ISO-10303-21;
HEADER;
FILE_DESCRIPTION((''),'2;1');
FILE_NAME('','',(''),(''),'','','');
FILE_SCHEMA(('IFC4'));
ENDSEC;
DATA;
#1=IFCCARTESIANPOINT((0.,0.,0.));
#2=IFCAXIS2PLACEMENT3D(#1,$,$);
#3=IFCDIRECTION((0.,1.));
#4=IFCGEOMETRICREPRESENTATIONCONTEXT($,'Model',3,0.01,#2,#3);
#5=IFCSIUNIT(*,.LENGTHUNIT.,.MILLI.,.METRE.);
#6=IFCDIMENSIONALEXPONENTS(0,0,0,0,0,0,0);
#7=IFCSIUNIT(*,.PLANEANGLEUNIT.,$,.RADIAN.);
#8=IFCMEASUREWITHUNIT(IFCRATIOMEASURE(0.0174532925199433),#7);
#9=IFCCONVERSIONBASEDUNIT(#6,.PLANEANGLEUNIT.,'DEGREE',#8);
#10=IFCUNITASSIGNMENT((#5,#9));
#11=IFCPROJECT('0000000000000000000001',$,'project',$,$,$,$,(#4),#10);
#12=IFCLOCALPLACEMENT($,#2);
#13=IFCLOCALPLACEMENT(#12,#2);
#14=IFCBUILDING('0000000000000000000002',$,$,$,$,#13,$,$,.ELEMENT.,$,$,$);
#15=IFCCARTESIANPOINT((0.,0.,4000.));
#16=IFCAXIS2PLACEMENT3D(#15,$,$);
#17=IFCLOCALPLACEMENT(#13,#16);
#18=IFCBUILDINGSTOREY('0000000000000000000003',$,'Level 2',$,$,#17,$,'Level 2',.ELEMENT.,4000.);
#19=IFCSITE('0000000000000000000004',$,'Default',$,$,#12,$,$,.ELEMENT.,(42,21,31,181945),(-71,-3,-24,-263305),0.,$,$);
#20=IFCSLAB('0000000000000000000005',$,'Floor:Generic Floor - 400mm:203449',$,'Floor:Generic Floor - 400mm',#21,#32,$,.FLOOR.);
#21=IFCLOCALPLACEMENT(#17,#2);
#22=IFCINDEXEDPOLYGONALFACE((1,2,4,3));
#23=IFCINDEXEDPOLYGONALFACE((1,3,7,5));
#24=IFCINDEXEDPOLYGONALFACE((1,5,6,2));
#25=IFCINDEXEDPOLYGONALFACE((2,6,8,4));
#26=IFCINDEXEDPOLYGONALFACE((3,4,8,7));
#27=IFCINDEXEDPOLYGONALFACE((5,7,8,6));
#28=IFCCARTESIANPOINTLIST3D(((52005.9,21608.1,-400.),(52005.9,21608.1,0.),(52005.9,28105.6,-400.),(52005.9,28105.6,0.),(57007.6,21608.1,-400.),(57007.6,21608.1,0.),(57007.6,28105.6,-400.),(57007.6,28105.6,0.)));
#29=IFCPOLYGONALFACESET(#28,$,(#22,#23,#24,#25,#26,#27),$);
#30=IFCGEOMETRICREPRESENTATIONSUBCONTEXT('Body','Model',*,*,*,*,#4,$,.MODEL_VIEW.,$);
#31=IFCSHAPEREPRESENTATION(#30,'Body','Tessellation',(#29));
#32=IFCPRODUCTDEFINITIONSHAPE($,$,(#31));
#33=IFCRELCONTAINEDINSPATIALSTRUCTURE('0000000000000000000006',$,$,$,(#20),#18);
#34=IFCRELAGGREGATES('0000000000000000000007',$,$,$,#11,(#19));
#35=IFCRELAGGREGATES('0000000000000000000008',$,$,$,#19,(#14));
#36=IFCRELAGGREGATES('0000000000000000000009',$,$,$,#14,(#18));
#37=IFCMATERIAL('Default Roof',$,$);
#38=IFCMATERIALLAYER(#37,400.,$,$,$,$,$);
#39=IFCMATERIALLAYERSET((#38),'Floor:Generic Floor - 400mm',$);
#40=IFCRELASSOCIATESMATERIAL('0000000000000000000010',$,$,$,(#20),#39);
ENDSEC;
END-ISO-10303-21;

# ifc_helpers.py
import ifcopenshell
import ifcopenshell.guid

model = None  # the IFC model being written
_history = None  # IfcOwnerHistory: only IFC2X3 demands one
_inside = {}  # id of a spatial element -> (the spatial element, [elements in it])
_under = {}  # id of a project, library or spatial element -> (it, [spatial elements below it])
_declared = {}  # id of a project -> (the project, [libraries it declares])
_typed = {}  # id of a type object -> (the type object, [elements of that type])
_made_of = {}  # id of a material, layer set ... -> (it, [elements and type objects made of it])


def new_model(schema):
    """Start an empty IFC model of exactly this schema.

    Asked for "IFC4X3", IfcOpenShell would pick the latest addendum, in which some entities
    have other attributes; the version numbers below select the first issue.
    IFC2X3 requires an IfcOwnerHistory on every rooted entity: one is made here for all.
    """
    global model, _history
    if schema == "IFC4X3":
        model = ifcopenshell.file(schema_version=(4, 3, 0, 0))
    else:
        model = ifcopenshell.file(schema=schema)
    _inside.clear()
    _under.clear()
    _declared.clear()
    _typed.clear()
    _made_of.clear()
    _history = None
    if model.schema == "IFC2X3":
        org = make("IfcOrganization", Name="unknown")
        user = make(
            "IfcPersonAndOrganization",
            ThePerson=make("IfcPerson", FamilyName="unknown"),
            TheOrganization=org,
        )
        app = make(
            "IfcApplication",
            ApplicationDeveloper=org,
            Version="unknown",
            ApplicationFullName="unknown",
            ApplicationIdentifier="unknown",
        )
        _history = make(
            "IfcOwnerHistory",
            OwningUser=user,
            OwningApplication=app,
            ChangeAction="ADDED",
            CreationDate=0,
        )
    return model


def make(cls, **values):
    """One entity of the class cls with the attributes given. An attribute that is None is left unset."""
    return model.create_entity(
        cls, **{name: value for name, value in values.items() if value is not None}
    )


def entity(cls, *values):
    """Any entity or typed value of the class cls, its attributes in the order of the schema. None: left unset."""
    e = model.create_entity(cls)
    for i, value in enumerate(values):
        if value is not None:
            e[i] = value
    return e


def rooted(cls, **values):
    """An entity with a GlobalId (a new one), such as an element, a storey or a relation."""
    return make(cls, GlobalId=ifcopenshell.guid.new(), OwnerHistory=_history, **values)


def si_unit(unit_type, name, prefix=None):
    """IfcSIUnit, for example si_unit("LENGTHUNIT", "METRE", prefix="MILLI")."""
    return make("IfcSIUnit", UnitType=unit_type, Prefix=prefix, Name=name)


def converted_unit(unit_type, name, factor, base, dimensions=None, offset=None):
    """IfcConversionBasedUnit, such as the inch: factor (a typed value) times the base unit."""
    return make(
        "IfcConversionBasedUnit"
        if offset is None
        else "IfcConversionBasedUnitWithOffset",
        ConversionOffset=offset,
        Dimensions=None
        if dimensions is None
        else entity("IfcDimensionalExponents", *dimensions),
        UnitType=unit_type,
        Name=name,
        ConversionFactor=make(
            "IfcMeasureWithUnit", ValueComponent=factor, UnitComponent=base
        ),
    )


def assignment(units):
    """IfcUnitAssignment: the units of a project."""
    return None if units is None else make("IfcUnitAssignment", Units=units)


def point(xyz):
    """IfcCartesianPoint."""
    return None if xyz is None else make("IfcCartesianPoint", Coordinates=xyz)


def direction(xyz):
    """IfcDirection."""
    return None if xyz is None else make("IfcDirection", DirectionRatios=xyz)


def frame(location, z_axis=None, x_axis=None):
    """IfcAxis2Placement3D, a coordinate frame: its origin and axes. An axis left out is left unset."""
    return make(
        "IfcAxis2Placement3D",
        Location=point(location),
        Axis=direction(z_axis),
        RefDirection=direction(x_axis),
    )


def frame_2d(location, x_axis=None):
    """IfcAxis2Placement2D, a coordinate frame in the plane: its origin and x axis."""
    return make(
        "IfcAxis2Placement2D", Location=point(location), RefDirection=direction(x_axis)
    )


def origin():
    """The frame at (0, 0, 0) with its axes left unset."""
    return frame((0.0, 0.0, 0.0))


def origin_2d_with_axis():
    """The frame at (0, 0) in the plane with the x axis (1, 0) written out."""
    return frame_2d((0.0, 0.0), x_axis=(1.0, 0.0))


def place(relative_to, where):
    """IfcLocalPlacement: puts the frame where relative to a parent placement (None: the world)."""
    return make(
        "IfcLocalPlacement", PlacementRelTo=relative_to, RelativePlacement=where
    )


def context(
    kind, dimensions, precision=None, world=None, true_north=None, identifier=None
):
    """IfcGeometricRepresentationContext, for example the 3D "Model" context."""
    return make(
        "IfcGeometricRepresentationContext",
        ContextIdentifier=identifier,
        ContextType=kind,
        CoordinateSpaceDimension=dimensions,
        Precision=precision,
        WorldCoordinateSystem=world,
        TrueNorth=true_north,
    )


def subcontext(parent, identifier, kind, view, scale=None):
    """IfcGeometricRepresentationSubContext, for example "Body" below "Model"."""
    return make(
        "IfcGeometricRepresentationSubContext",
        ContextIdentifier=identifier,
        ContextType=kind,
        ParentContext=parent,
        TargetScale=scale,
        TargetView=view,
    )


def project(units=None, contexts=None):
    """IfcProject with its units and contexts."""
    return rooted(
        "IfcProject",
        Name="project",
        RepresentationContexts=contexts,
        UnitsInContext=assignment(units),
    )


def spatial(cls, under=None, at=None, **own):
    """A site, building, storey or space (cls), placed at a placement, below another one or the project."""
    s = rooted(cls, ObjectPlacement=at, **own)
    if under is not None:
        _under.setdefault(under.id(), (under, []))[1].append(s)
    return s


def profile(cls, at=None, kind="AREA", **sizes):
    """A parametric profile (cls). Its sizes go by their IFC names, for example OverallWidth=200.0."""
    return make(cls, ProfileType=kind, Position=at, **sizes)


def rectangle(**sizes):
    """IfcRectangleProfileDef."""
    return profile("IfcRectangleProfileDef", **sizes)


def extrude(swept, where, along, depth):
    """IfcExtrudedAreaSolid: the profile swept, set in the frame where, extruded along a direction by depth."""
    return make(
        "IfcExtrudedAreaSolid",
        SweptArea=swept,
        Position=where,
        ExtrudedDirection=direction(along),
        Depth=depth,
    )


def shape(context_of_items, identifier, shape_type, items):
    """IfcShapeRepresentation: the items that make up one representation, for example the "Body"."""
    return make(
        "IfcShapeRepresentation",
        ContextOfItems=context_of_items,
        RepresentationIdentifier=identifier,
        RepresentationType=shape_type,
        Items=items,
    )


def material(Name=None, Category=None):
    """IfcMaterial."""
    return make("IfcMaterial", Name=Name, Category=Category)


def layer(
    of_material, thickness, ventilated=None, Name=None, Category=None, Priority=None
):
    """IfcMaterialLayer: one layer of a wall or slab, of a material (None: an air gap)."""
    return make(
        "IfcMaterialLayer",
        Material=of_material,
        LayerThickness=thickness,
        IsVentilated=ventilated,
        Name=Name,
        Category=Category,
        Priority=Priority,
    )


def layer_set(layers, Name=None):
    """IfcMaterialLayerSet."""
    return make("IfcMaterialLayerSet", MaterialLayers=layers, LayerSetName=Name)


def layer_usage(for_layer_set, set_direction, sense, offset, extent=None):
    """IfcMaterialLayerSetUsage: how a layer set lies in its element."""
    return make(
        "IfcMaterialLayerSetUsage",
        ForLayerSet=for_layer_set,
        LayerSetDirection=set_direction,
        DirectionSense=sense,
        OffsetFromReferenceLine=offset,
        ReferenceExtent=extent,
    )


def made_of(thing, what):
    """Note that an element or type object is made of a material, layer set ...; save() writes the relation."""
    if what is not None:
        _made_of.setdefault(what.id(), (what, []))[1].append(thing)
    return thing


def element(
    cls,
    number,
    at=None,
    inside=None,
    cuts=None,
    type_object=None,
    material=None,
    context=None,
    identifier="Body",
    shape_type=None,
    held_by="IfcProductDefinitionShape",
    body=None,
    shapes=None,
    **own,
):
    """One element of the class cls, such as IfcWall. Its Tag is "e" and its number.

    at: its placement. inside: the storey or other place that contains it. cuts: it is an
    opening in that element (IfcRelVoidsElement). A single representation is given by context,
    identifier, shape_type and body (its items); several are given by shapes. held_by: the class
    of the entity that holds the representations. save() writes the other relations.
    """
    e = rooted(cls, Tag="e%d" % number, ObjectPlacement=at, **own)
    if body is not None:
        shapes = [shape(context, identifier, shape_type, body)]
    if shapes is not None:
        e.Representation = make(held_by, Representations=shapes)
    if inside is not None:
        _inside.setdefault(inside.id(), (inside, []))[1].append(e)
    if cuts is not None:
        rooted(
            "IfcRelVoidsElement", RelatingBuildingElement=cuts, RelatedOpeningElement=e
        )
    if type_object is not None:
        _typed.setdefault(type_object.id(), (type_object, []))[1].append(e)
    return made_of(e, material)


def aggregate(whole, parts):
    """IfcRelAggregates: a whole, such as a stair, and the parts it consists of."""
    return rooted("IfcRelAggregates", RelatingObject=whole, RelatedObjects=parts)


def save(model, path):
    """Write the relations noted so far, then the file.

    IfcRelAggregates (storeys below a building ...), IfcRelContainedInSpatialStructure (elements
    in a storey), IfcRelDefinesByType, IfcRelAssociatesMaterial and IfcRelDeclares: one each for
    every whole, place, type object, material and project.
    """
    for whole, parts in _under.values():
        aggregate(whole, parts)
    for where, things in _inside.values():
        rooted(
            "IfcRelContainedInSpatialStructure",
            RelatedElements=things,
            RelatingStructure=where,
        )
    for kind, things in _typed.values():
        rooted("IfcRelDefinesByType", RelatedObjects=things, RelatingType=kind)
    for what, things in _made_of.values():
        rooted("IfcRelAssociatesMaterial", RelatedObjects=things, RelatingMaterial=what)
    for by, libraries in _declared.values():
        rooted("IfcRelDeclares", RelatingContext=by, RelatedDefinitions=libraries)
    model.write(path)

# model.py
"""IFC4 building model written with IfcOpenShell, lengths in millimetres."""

from ifc_helpers import new_model, entity, si_unit, converted_unit, direction, frame, origin, origin_2d_with_axis, place, context, subcontext, project, spatial, rectangle, extrude, material, layer, layer_set, layer_usage, element, save


model = new_model("IFC4")

# Units and contexts
model_context = context("Model", 3, precision=0.01, world=origin(), true_north=direction((0.0, 1.0)))
body_context = subcontext(model_context, "Body", "Model", "MODEL_VIEW")
ifc_project = project(units=[si_unit("LENGTHUNIT", "METRE", prefix="MILLI"), converted_unit("PLANEANGLEUNIT", "DEGREE", entity("IfcRatioMeasure", 0.0174532925199433), si_unit("PLANEANGLEUNIT", "RADIAN"), dimensions=[0, 0, 0, 0, 0, 0, 0])], contexts=[model_context])

# Site, building, storey
site_placement = place(None, origin())
site = spatial("IfcSite", under=ifc_project, at=site_placement, Name="Default", CompositionType="ELEMENT", RefLatitude=(42, 21, 31, 181945), RefLongitude=(-71, -3, -24, -263305), RefElevation=0.0)
building_placement = place(site_placement, origin())
building = spatial("IfcBuilding", under=site, at=building_placement, CompositionType="ELEMENT")
storey_placement = place(building_placement, frame((0.0, 0.0, 4000.0)))
storey = spatial("IfcBuildingStorey", under=building, at=storey_placement, Name="Level 2", LongName="Level 2", CompositionType="ELEMENT", Elevation=4000.0)

# Slab
ifc_material = material(Name="Default Roof")
ifc_layer = layer(ifc_material, 400.0)
ifc_layer_set = layer_set([ifc_layer], Name="Floor:Generic Floor - 400mm")
ifc_layer_usage = layer_usage(ifc_layer_set, "AXIS3", "POSITIVE", 0.0)
slab_placement = place(storey_placement, origin())
element("IfcSlab", 1, at=slab_placement, inside=storey, material=ifc_layer_usage, Name="Floor:Generic Floor - 400mm:203449", ObjectType="Floor:Generic Floor - 400mm", PredefinedType="FLOOR", context=body_context, shape_type="SweptSolid", body=[
    extrude(rectangle(XDim=6497.5, YDim=5001.7, at=origin_2d_with_axis()), frame((54506.7, 24856.8, 0.0), z_axis=(0.0, 0.0, -1.0), x_axis=(0.0, 1.0, 0.0)), (0.0, 0.0, 1.0), 400.0),
])

save(model, "model.ifc")
